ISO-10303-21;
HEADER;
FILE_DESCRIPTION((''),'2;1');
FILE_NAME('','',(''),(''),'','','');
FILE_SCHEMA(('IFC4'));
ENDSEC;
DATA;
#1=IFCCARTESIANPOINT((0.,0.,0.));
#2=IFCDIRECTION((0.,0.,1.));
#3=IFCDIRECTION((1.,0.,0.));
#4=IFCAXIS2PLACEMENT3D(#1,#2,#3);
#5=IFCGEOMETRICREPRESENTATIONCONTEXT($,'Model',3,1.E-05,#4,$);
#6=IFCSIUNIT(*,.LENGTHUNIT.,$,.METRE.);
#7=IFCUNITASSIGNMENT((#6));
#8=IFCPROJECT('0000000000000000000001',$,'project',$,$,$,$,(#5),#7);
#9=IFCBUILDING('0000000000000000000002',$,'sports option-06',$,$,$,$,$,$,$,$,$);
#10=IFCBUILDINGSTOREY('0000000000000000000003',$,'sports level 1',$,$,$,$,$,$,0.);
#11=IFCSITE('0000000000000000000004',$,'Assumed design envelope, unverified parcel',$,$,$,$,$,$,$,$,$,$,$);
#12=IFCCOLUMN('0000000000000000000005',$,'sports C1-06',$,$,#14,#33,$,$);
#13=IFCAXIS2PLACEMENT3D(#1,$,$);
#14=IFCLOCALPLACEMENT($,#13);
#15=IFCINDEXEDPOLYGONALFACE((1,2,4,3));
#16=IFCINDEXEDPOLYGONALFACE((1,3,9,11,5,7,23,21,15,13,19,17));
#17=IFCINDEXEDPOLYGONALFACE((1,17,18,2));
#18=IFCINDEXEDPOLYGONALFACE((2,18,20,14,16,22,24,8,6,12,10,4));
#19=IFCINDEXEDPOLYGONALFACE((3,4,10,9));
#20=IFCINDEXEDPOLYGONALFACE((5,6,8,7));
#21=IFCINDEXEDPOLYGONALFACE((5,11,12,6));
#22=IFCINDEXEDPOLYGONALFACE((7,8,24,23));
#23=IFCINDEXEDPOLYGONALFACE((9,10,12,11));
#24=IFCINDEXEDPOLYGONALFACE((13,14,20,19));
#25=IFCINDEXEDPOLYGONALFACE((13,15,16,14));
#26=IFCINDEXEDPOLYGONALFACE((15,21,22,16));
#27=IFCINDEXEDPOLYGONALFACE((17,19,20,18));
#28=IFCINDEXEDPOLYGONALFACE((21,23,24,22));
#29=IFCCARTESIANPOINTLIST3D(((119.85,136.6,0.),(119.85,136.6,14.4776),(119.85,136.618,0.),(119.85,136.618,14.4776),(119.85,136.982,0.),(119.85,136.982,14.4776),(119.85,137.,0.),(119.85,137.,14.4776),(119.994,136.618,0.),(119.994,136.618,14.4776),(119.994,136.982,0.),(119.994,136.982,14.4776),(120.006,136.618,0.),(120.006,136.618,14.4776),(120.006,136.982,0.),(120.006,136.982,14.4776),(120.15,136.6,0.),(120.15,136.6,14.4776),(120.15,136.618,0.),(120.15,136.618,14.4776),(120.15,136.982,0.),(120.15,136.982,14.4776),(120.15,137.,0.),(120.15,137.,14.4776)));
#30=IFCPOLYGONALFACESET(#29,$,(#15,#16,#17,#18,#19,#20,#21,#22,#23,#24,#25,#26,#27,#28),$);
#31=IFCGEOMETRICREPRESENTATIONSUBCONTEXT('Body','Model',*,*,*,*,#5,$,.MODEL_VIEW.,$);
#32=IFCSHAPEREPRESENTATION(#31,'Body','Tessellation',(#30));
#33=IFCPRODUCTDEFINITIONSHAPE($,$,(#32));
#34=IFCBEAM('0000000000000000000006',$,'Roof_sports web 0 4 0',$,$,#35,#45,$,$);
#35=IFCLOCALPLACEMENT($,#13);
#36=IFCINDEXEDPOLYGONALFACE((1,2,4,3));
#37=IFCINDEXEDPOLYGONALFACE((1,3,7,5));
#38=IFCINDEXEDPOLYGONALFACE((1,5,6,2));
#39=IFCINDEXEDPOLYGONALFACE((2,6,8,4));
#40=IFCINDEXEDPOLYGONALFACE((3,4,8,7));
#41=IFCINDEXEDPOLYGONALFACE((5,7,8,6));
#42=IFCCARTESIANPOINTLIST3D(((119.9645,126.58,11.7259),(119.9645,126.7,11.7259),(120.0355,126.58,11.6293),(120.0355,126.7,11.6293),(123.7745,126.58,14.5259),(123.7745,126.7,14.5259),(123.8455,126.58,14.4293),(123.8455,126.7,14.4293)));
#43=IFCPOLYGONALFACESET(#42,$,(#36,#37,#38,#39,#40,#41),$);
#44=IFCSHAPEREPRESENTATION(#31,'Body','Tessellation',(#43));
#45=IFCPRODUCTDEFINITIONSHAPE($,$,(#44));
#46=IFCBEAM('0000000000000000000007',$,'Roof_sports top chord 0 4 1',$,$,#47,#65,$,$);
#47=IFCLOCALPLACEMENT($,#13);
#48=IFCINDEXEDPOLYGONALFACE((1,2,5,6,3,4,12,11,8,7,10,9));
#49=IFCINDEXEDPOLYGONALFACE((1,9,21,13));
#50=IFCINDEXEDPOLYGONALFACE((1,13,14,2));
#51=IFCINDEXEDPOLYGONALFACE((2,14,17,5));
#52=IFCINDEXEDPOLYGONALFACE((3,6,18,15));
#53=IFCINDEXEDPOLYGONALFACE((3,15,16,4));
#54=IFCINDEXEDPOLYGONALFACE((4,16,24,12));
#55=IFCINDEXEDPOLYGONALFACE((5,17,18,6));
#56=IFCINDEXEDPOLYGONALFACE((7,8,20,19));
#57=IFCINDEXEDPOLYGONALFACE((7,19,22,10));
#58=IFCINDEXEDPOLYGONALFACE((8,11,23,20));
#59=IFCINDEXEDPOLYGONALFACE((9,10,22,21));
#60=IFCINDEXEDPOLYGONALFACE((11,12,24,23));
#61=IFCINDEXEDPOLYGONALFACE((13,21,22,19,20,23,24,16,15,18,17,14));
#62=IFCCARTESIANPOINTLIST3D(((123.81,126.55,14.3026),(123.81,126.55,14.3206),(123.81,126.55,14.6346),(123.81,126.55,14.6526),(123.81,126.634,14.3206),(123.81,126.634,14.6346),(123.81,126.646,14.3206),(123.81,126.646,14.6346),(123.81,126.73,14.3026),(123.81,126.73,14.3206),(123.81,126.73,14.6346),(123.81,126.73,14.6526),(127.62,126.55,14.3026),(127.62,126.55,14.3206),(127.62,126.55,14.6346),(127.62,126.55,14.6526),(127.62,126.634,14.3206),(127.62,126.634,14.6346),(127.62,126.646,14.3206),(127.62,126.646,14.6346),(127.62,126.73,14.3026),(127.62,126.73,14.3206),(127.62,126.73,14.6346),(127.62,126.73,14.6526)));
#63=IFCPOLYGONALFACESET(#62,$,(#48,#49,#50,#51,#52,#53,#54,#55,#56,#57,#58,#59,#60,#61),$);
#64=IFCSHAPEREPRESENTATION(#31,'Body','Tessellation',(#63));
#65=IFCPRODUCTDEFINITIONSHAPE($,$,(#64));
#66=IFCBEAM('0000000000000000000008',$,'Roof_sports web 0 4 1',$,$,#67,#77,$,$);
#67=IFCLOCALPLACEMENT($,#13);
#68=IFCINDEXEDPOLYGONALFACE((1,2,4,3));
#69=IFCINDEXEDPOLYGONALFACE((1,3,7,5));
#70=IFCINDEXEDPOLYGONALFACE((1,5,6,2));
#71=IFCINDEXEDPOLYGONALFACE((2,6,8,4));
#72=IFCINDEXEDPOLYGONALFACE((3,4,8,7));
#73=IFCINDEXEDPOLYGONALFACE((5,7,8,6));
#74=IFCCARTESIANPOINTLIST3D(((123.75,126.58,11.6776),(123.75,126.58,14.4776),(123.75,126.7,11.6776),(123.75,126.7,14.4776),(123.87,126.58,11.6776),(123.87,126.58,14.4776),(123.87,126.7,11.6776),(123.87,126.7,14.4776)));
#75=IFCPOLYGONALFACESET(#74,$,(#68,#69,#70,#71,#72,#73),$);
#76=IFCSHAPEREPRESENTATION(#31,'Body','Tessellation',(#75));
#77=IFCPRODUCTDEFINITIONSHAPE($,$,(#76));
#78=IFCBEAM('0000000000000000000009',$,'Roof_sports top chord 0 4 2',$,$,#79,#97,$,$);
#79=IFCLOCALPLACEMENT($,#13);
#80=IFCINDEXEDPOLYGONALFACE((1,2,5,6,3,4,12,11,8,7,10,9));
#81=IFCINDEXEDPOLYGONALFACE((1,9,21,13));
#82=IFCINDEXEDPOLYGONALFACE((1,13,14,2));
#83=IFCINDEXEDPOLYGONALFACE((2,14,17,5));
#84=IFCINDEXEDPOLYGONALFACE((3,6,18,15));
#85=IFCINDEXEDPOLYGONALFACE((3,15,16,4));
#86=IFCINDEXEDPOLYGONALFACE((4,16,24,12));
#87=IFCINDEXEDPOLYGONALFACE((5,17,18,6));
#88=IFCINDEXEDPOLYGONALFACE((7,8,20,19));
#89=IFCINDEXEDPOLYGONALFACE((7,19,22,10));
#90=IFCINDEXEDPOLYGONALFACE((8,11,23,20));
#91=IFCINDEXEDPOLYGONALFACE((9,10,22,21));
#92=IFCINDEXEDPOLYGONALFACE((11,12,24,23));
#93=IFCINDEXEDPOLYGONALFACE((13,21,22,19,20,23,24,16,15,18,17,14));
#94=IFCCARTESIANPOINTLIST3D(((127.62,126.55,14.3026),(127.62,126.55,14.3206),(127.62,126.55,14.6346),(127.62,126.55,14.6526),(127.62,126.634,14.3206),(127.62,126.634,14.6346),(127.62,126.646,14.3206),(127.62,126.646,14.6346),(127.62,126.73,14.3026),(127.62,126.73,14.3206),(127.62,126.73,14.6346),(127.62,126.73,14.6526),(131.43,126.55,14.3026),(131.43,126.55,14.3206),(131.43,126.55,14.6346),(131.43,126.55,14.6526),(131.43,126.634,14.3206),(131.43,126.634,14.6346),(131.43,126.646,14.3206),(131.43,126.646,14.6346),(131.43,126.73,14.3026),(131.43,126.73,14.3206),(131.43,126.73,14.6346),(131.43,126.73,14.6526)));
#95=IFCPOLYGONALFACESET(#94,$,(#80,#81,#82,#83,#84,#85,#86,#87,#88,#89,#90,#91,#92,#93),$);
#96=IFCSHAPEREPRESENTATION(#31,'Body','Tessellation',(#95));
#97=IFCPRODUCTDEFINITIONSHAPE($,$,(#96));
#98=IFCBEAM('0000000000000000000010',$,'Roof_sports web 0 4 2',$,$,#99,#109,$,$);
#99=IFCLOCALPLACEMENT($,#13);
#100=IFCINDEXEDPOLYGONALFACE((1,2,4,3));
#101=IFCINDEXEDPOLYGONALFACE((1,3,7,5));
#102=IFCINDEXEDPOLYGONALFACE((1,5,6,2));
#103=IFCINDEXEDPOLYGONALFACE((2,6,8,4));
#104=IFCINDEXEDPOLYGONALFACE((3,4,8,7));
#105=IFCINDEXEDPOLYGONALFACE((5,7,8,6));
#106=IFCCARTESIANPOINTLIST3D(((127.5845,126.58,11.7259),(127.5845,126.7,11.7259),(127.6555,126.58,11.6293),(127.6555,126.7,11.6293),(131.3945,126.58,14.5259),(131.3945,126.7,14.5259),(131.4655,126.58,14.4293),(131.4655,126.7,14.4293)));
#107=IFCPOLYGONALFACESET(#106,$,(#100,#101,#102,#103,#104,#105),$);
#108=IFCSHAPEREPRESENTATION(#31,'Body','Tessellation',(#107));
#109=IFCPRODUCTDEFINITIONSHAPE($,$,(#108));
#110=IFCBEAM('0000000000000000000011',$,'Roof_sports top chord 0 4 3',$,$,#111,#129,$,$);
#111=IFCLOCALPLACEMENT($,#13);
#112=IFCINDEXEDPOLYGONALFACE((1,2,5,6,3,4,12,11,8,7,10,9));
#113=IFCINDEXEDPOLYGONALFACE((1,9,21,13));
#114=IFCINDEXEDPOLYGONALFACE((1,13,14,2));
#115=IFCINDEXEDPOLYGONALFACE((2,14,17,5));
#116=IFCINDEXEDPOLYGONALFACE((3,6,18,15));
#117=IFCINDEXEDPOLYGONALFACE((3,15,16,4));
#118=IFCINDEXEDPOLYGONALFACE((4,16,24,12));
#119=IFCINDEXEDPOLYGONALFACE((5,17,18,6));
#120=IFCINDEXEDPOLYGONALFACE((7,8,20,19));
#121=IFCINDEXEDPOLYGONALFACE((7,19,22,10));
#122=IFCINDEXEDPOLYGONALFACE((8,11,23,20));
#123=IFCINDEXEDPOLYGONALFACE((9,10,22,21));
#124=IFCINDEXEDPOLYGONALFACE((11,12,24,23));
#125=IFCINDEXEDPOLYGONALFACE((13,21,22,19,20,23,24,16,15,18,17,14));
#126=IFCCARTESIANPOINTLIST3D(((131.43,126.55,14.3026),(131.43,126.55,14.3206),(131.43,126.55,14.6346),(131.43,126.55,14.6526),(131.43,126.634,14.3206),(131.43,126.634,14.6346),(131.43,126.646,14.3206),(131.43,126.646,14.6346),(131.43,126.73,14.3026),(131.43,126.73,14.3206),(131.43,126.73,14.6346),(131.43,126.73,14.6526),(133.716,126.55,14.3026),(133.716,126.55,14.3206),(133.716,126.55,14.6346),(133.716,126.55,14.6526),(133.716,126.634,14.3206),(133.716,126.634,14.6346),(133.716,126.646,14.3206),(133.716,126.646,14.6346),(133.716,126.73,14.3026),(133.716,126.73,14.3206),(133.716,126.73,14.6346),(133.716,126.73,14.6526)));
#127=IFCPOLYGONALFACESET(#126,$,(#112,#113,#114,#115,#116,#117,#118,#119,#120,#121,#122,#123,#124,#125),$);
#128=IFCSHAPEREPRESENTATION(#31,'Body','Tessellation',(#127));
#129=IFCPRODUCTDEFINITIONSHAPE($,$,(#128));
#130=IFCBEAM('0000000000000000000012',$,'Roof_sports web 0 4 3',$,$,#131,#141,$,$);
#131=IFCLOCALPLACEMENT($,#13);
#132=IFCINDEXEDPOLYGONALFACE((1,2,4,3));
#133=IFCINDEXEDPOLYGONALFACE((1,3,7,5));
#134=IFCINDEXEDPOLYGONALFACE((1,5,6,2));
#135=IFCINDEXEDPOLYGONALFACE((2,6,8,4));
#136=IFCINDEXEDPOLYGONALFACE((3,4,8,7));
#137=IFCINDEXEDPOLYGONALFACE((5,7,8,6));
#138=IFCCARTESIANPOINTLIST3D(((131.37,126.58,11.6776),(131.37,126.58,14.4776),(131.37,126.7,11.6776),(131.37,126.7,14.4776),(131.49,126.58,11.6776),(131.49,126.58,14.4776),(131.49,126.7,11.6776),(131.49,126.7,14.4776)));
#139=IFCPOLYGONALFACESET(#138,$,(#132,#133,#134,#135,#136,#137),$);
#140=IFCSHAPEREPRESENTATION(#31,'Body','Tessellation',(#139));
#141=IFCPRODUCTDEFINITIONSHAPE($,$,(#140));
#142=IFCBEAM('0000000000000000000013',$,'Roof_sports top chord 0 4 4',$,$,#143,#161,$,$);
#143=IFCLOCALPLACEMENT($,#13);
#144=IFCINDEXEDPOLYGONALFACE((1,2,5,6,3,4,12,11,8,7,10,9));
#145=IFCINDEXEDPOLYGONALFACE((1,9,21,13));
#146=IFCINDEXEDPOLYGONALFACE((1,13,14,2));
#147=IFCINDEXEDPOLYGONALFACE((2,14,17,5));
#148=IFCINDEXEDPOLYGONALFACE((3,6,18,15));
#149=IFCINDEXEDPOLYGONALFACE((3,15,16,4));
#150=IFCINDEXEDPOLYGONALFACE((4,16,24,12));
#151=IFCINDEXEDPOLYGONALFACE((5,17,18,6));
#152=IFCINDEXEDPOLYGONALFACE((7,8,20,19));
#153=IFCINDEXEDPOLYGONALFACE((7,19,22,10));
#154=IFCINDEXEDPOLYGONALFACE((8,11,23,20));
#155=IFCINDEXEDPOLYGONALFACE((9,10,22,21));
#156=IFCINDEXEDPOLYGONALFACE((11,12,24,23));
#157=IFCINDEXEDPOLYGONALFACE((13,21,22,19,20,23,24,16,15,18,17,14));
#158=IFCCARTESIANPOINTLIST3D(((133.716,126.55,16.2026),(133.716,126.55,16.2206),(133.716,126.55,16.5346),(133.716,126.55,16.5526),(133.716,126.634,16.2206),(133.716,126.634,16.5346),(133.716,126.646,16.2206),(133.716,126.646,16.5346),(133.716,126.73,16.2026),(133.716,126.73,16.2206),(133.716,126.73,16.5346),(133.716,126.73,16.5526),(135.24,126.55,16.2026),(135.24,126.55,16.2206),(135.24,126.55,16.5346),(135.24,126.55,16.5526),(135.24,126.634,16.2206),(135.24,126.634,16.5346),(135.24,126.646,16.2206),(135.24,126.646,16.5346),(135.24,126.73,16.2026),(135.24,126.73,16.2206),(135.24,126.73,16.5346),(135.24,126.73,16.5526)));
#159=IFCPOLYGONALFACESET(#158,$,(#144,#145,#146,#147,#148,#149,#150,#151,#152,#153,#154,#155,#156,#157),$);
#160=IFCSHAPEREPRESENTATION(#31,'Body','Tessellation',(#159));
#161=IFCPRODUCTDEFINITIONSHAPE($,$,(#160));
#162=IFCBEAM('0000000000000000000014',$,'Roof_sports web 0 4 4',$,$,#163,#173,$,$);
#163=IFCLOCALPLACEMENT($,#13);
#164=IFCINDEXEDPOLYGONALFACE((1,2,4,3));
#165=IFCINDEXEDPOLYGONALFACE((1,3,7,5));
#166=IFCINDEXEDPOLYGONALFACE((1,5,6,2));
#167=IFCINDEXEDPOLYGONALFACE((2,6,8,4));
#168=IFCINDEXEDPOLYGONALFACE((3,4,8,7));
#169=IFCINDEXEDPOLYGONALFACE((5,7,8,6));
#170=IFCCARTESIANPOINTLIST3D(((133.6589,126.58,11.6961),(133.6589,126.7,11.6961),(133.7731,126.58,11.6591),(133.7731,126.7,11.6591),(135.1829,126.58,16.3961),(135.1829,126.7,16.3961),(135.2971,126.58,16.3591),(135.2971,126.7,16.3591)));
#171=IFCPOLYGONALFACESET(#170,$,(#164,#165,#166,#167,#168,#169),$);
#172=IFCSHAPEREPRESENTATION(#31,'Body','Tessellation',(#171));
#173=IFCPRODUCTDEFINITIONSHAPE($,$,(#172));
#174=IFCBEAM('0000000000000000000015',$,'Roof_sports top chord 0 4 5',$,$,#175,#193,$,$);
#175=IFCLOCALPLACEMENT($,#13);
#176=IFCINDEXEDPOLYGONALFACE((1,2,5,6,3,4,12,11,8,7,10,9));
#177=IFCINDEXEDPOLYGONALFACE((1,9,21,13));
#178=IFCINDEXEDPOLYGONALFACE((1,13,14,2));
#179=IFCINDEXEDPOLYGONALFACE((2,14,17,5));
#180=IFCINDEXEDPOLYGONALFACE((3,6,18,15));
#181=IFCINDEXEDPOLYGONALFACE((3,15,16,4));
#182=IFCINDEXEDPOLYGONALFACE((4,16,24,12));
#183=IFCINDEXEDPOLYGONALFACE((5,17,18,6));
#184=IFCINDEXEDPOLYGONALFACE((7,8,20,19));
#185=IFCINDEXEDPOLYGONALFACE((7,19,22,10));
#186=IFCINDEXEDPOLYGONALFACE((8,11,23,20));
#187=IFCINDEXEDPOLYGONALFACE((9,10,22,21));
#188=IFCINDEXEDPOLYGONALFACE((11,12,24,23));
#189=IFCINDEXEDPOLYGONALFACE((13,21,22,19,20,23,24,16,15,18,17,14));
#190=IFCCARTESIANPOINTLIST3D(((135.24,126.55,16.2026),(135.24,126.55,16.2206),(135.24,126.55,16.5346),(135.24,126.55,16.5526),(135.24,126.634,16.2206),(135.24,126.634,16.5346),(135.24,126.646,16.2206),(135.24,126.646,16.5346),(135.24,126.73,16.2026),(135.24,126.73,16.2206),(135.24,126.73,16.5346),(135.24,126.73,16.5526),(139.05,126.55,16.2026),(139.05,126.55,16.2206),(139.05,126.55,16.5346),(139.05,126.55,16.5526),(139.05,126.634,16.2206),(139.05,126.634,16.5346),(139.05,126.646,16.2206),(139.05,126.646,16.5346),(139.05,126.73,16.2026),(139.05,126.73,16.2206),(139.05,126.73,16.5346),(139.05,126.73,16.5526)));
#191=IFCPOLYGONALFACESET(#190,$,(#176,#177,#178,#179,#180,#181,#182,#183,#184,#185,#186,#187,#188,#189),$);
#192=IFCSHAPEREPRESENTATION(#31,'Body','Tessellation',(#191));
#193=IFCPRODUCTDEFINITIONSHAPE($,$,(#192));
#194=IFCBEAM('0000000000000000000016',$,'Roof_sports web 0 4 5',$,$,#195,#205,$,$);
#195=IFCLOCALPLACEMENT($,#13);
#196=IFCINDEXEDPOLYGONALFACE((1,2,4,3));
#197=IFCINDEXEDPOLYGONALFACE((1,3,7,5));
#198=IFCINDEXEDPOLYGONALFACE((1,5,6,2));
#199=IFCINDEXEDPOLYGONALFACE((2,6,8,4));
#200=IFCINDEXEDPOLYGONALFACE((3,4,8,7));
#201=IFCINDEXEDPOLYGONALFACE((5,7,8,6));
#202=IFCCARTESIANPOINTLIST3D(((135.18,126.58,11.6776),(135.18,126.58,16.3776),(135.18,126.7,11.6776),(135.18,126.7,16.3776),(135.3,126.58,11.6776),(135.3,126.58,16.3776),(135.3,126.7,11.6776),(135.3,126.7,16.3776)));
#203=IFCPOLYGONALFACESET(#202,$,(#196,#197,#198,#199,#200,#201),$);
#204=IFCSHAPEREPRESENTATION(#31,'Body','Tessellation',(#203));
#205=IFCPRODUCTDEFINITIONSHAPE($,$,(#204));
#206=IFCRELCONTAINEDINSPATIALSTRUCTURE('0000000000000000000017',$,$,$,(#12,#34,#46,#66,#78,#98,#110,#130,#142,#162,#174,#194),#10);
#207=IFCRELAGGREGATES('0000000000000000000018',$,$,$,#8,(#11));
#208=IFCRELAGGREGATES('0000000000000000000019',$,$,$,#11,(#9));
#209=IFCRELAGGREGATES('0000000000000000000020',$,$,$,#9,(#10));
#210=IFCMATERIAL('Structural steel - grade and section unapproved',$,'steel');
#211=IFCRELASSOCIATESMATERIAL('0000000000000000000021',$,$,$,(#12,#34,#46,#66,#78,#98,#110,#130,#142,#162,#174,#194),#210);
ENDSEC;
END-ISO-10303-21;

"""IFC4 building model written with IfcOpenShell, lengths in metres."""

from ifc_helpers import new_model, si_unit, frame, origin_with_axes, place, context, subcontext, project, spatial, rectangle, i_section, extrude, material, element, save


model = new_model("IFC4")

# Units and contexts
model_context = context("Model", 3, precision=1e-05, world=origin_with_axes())
body_context = subcontext(model_context, "Body", "Model", "MODEL_VIEW")
ifc_project = project(units=[si_unit("LENGTHUNIT", "METRE")], contexts=[model_context])

# Site, building, storey
site = spatial("IfcSite", under=ifc_project, Name="Assumed design envelope, unverified parcel")
building = spatial("IfcBuilding", under=site, Name="sports option-06")
storey = spatial("IfcBuildingStorey", under=building, Name="sports level 1", Elevation=0.0)

# Column
ifc_material_1 = material(Name="Structural steel - grade and section unapproved", Category="steel")
column_placement = place(None, frame((120.0, 136.8, 0.0), z_axis=(0.0, 0.0, 1.0), x_axis=(-1.0, 0.0, 0.0)))
element("IfcColumn", 1, at=column_placement, inside=storey, material=ifc_material_1, Name="sports C1-06", context=body_context, shape_type="SweptSolid", body=[
    extrude(i_section(OverallWidth=0.3, OverallDepth=0.4, WebThickness=0.012, FlangeThickness=0.018, FilletRadius=0.0), origin_with_axes(), (0.0, 0.0, 1.0), 14.4776),
])

# Beams
beam_1_placement = place(None, frame((120.0, 126.64, 11.6776), z_axis=(0.805799, 0.0, 0.592189), x_axis=(0.0, 1.0, 0.0)))
element("IfcBeam", 2, at=beam_1_placement, inside=storey, material=ifc_material_1, Name="Roof_sports web 0 4 0", context=body_context, shape_type="SweptSolid", body=[
    extrude(rectangle(XDim=0.12, YDim=0.12), origin_with_axes(), (0.0, 0.0, 1.0), 4.7282),
])
beam_2_placement = place(None, frame((123.81, 126.64, 14.4776), z_axis=(1.0, 0.0, 0.0), x_axis=(0.0, 1.0, 0.0)))
element("IfcBeam", 3, at=beam_2_placement, inside=storey, material=ifc_material_1, Name="Roof_sports top chord 0 4 1", context=body_context, shape_type="SweptSolid", body=[
    extrude(i_section(OverallWidth=0.18, OverallDepth=0.35, WebThickness=0.012, FlangeThickness=0.018, FilletRadius=0.0), origin_with_axes(), (0.0, 0.0, 1.0), 3.81),
])
beam_3_placement = place(None, frame((123.81, 126.64, 11.6776), z_axis=(0.0, 0.0, 1.0), x_axis=(-1.0, 0.0, 0.0)))
element("IfcBeam", 4, at=beam_3_placement, inside=storey, material=ifc_material_1, Name="Roof_sports web 0 4 1", context=body_context, shape_type="SweptSolid", body=[
    extrude(rectangle(XDim=0.12, YDim=0.12), origin_with_axes(), (0.0, 0.0, 1.0), 2.8),
])
beam_4_placement = place(None, frame((127.62, 126.64, 14.4776), z_axis=(1.0, 0.0, 0.0), x_axis=(0.0, 1.0, 0.0)))
element("IfcBeam", 5, at=beam_4_placement, inside=storey, material=ifc_material_1, Name="Roof_sports top chord 0 4 2", context=body_context, shape_type="SweptSolid", body=[
    extrude(i_section(OverallWidth=0.18, OverallDepth=0.35, WebThickness=0.012, FlangeThickness=0.018, FilletRadius=0.0), origin_with_axes(), (0.0, 0.0, 1.0), 3.81),
])
beam_5_placement = place(None, frame((127.62, 126.64, 11.6776), z_axis=(0.805799, 0.0, 0.59219), x_axis=(0.0, 1.0, 0.0)))
element("IfcBeam", 6, at=beam_5_placement, inside=storey, material=ifc_material_1, Name="Roof_sports web 0 4 2", context=body_context, shape_type="SweptSolid", body=[
    extrude(rectangle(XDim=0.12, YDim=0.12), origin_with_axes(), (0.0, 0.0, 1.0), 4.7282),
])
beam_6_placement = place(None, frame((131.43, 126.64, 14.4776), z_axis=(1.0, 0.0, 0.0), x_axis=(0.0, 1.0, 0.0)))
element("IfcBeam", 7, at=beam_6_placement, inside=storey, material=ifc_material_1, Name="Roof_sports top chord 0 4 3", context=body_context, shape_type="SweptSolid", body=[
    extrude(i_section(OverallWidth=0.18, OverallDepth=0.35, WebThickness=0.012, FlangeThickness=0.018, FilletRadius=0.0), origin_with_axes(), (0.0, 0.0, 1.0), 2.286),
])
beam_7_placement = place(None, frame((131.43, 126.64, 11.6776), z_axis=(0.0, 0.0, 1.0), x_axis=(-1.0, 0.0, 0.0)))
element("IfcBeam", 8, at=beam_7_placement, inside=storey, material=ifc_material_1, Name="Roof_sports web 0 4 3", context=body_context, shape_type="SweptSolid", body=[
    extrude(rectangle(XDim=0.12, YDim=0.12), origin_with_axes(), (0.0, 0.0, 1.0), 2.8),
])
beam_8_placement = place(None, frame((133.716, 126.64, 16.3776), z_axis=(1.0, 0.0, 0.0), x_axis=(0.0, 1.0, 0.0)))
element("IfcBeam", 9, at=beam_8_placement, inside=storey, material=ifc_material_1, Name="Roof_sports top chord 0 4 4", context=body_context, shape_type="SweptSolid", body=[
    extrude(i_section(OverallWidth=0.18, OverallDepth=0.35, WebThickness=0.012, FlangeThickness=0.018, FilletRadius=0.0), origin_with_axes(), (0.0, 0.0, 1.0), 1.524),
])
beam_9_placement = place(None, frame((133.716, 126.64, 11.6776), z_axis=(0.308446, 0.0, 0.951242), x_axis=(0.0, 1.0, 0.0)))
element("IfcBeam", 10, at=beam_9_placement, inside=storey, material=ifc_material_1, Name="Roof_sports web 0 4 4", context=body_context, shape_type="SweptSolid", body=[
    extrude(rectangle(XDim=0.12, YDim=0.12), origin_with_axes(), (0.0, 0.0, 1.0), 4.9409),
])
beam_10_placement = place(None, frame((135.24, 126.64, 16.3776), z_axis=(1.0, 0.0, 0.0), x_axis=(0.0, 1.0, 0.0)))
element("IfcBeam", 11, at=beam_10_placement, inside=storey, material=ifc_material_1, Name="Roof_sports top chord 0 4 5", context=body_context, shape_type="SweptSolid", body=[
    extrude(i_section(OverallWidth=0.18, OverallDepth=0.35, WebThickness=0.012, FlangeThickness=0.018, FilletRadius=0.0), origin_with_axes(), (0.0, 0.0, 1.0), 3.81),
])
beam_11_placement = place(None, frame((135.24, 126.64, 11.6776), z_axis=(0.0, 0.0, 1.0), x_axis=(-1.0, 0.0, 0.0)))
element("IfcBeam", 12, at=beam_11_placement, inside=storey, material=ifc_material_1, Name="Roof_sports web 0 4 5", context=body_context, shape_type="SweptSolid", body=[
    extrude(rectangle(XDim=0.12, YDim=0.12), origin_with_axes(), (0.0, 0.0, 1.0), 4.7),
])

save(model, "model.ifc")
